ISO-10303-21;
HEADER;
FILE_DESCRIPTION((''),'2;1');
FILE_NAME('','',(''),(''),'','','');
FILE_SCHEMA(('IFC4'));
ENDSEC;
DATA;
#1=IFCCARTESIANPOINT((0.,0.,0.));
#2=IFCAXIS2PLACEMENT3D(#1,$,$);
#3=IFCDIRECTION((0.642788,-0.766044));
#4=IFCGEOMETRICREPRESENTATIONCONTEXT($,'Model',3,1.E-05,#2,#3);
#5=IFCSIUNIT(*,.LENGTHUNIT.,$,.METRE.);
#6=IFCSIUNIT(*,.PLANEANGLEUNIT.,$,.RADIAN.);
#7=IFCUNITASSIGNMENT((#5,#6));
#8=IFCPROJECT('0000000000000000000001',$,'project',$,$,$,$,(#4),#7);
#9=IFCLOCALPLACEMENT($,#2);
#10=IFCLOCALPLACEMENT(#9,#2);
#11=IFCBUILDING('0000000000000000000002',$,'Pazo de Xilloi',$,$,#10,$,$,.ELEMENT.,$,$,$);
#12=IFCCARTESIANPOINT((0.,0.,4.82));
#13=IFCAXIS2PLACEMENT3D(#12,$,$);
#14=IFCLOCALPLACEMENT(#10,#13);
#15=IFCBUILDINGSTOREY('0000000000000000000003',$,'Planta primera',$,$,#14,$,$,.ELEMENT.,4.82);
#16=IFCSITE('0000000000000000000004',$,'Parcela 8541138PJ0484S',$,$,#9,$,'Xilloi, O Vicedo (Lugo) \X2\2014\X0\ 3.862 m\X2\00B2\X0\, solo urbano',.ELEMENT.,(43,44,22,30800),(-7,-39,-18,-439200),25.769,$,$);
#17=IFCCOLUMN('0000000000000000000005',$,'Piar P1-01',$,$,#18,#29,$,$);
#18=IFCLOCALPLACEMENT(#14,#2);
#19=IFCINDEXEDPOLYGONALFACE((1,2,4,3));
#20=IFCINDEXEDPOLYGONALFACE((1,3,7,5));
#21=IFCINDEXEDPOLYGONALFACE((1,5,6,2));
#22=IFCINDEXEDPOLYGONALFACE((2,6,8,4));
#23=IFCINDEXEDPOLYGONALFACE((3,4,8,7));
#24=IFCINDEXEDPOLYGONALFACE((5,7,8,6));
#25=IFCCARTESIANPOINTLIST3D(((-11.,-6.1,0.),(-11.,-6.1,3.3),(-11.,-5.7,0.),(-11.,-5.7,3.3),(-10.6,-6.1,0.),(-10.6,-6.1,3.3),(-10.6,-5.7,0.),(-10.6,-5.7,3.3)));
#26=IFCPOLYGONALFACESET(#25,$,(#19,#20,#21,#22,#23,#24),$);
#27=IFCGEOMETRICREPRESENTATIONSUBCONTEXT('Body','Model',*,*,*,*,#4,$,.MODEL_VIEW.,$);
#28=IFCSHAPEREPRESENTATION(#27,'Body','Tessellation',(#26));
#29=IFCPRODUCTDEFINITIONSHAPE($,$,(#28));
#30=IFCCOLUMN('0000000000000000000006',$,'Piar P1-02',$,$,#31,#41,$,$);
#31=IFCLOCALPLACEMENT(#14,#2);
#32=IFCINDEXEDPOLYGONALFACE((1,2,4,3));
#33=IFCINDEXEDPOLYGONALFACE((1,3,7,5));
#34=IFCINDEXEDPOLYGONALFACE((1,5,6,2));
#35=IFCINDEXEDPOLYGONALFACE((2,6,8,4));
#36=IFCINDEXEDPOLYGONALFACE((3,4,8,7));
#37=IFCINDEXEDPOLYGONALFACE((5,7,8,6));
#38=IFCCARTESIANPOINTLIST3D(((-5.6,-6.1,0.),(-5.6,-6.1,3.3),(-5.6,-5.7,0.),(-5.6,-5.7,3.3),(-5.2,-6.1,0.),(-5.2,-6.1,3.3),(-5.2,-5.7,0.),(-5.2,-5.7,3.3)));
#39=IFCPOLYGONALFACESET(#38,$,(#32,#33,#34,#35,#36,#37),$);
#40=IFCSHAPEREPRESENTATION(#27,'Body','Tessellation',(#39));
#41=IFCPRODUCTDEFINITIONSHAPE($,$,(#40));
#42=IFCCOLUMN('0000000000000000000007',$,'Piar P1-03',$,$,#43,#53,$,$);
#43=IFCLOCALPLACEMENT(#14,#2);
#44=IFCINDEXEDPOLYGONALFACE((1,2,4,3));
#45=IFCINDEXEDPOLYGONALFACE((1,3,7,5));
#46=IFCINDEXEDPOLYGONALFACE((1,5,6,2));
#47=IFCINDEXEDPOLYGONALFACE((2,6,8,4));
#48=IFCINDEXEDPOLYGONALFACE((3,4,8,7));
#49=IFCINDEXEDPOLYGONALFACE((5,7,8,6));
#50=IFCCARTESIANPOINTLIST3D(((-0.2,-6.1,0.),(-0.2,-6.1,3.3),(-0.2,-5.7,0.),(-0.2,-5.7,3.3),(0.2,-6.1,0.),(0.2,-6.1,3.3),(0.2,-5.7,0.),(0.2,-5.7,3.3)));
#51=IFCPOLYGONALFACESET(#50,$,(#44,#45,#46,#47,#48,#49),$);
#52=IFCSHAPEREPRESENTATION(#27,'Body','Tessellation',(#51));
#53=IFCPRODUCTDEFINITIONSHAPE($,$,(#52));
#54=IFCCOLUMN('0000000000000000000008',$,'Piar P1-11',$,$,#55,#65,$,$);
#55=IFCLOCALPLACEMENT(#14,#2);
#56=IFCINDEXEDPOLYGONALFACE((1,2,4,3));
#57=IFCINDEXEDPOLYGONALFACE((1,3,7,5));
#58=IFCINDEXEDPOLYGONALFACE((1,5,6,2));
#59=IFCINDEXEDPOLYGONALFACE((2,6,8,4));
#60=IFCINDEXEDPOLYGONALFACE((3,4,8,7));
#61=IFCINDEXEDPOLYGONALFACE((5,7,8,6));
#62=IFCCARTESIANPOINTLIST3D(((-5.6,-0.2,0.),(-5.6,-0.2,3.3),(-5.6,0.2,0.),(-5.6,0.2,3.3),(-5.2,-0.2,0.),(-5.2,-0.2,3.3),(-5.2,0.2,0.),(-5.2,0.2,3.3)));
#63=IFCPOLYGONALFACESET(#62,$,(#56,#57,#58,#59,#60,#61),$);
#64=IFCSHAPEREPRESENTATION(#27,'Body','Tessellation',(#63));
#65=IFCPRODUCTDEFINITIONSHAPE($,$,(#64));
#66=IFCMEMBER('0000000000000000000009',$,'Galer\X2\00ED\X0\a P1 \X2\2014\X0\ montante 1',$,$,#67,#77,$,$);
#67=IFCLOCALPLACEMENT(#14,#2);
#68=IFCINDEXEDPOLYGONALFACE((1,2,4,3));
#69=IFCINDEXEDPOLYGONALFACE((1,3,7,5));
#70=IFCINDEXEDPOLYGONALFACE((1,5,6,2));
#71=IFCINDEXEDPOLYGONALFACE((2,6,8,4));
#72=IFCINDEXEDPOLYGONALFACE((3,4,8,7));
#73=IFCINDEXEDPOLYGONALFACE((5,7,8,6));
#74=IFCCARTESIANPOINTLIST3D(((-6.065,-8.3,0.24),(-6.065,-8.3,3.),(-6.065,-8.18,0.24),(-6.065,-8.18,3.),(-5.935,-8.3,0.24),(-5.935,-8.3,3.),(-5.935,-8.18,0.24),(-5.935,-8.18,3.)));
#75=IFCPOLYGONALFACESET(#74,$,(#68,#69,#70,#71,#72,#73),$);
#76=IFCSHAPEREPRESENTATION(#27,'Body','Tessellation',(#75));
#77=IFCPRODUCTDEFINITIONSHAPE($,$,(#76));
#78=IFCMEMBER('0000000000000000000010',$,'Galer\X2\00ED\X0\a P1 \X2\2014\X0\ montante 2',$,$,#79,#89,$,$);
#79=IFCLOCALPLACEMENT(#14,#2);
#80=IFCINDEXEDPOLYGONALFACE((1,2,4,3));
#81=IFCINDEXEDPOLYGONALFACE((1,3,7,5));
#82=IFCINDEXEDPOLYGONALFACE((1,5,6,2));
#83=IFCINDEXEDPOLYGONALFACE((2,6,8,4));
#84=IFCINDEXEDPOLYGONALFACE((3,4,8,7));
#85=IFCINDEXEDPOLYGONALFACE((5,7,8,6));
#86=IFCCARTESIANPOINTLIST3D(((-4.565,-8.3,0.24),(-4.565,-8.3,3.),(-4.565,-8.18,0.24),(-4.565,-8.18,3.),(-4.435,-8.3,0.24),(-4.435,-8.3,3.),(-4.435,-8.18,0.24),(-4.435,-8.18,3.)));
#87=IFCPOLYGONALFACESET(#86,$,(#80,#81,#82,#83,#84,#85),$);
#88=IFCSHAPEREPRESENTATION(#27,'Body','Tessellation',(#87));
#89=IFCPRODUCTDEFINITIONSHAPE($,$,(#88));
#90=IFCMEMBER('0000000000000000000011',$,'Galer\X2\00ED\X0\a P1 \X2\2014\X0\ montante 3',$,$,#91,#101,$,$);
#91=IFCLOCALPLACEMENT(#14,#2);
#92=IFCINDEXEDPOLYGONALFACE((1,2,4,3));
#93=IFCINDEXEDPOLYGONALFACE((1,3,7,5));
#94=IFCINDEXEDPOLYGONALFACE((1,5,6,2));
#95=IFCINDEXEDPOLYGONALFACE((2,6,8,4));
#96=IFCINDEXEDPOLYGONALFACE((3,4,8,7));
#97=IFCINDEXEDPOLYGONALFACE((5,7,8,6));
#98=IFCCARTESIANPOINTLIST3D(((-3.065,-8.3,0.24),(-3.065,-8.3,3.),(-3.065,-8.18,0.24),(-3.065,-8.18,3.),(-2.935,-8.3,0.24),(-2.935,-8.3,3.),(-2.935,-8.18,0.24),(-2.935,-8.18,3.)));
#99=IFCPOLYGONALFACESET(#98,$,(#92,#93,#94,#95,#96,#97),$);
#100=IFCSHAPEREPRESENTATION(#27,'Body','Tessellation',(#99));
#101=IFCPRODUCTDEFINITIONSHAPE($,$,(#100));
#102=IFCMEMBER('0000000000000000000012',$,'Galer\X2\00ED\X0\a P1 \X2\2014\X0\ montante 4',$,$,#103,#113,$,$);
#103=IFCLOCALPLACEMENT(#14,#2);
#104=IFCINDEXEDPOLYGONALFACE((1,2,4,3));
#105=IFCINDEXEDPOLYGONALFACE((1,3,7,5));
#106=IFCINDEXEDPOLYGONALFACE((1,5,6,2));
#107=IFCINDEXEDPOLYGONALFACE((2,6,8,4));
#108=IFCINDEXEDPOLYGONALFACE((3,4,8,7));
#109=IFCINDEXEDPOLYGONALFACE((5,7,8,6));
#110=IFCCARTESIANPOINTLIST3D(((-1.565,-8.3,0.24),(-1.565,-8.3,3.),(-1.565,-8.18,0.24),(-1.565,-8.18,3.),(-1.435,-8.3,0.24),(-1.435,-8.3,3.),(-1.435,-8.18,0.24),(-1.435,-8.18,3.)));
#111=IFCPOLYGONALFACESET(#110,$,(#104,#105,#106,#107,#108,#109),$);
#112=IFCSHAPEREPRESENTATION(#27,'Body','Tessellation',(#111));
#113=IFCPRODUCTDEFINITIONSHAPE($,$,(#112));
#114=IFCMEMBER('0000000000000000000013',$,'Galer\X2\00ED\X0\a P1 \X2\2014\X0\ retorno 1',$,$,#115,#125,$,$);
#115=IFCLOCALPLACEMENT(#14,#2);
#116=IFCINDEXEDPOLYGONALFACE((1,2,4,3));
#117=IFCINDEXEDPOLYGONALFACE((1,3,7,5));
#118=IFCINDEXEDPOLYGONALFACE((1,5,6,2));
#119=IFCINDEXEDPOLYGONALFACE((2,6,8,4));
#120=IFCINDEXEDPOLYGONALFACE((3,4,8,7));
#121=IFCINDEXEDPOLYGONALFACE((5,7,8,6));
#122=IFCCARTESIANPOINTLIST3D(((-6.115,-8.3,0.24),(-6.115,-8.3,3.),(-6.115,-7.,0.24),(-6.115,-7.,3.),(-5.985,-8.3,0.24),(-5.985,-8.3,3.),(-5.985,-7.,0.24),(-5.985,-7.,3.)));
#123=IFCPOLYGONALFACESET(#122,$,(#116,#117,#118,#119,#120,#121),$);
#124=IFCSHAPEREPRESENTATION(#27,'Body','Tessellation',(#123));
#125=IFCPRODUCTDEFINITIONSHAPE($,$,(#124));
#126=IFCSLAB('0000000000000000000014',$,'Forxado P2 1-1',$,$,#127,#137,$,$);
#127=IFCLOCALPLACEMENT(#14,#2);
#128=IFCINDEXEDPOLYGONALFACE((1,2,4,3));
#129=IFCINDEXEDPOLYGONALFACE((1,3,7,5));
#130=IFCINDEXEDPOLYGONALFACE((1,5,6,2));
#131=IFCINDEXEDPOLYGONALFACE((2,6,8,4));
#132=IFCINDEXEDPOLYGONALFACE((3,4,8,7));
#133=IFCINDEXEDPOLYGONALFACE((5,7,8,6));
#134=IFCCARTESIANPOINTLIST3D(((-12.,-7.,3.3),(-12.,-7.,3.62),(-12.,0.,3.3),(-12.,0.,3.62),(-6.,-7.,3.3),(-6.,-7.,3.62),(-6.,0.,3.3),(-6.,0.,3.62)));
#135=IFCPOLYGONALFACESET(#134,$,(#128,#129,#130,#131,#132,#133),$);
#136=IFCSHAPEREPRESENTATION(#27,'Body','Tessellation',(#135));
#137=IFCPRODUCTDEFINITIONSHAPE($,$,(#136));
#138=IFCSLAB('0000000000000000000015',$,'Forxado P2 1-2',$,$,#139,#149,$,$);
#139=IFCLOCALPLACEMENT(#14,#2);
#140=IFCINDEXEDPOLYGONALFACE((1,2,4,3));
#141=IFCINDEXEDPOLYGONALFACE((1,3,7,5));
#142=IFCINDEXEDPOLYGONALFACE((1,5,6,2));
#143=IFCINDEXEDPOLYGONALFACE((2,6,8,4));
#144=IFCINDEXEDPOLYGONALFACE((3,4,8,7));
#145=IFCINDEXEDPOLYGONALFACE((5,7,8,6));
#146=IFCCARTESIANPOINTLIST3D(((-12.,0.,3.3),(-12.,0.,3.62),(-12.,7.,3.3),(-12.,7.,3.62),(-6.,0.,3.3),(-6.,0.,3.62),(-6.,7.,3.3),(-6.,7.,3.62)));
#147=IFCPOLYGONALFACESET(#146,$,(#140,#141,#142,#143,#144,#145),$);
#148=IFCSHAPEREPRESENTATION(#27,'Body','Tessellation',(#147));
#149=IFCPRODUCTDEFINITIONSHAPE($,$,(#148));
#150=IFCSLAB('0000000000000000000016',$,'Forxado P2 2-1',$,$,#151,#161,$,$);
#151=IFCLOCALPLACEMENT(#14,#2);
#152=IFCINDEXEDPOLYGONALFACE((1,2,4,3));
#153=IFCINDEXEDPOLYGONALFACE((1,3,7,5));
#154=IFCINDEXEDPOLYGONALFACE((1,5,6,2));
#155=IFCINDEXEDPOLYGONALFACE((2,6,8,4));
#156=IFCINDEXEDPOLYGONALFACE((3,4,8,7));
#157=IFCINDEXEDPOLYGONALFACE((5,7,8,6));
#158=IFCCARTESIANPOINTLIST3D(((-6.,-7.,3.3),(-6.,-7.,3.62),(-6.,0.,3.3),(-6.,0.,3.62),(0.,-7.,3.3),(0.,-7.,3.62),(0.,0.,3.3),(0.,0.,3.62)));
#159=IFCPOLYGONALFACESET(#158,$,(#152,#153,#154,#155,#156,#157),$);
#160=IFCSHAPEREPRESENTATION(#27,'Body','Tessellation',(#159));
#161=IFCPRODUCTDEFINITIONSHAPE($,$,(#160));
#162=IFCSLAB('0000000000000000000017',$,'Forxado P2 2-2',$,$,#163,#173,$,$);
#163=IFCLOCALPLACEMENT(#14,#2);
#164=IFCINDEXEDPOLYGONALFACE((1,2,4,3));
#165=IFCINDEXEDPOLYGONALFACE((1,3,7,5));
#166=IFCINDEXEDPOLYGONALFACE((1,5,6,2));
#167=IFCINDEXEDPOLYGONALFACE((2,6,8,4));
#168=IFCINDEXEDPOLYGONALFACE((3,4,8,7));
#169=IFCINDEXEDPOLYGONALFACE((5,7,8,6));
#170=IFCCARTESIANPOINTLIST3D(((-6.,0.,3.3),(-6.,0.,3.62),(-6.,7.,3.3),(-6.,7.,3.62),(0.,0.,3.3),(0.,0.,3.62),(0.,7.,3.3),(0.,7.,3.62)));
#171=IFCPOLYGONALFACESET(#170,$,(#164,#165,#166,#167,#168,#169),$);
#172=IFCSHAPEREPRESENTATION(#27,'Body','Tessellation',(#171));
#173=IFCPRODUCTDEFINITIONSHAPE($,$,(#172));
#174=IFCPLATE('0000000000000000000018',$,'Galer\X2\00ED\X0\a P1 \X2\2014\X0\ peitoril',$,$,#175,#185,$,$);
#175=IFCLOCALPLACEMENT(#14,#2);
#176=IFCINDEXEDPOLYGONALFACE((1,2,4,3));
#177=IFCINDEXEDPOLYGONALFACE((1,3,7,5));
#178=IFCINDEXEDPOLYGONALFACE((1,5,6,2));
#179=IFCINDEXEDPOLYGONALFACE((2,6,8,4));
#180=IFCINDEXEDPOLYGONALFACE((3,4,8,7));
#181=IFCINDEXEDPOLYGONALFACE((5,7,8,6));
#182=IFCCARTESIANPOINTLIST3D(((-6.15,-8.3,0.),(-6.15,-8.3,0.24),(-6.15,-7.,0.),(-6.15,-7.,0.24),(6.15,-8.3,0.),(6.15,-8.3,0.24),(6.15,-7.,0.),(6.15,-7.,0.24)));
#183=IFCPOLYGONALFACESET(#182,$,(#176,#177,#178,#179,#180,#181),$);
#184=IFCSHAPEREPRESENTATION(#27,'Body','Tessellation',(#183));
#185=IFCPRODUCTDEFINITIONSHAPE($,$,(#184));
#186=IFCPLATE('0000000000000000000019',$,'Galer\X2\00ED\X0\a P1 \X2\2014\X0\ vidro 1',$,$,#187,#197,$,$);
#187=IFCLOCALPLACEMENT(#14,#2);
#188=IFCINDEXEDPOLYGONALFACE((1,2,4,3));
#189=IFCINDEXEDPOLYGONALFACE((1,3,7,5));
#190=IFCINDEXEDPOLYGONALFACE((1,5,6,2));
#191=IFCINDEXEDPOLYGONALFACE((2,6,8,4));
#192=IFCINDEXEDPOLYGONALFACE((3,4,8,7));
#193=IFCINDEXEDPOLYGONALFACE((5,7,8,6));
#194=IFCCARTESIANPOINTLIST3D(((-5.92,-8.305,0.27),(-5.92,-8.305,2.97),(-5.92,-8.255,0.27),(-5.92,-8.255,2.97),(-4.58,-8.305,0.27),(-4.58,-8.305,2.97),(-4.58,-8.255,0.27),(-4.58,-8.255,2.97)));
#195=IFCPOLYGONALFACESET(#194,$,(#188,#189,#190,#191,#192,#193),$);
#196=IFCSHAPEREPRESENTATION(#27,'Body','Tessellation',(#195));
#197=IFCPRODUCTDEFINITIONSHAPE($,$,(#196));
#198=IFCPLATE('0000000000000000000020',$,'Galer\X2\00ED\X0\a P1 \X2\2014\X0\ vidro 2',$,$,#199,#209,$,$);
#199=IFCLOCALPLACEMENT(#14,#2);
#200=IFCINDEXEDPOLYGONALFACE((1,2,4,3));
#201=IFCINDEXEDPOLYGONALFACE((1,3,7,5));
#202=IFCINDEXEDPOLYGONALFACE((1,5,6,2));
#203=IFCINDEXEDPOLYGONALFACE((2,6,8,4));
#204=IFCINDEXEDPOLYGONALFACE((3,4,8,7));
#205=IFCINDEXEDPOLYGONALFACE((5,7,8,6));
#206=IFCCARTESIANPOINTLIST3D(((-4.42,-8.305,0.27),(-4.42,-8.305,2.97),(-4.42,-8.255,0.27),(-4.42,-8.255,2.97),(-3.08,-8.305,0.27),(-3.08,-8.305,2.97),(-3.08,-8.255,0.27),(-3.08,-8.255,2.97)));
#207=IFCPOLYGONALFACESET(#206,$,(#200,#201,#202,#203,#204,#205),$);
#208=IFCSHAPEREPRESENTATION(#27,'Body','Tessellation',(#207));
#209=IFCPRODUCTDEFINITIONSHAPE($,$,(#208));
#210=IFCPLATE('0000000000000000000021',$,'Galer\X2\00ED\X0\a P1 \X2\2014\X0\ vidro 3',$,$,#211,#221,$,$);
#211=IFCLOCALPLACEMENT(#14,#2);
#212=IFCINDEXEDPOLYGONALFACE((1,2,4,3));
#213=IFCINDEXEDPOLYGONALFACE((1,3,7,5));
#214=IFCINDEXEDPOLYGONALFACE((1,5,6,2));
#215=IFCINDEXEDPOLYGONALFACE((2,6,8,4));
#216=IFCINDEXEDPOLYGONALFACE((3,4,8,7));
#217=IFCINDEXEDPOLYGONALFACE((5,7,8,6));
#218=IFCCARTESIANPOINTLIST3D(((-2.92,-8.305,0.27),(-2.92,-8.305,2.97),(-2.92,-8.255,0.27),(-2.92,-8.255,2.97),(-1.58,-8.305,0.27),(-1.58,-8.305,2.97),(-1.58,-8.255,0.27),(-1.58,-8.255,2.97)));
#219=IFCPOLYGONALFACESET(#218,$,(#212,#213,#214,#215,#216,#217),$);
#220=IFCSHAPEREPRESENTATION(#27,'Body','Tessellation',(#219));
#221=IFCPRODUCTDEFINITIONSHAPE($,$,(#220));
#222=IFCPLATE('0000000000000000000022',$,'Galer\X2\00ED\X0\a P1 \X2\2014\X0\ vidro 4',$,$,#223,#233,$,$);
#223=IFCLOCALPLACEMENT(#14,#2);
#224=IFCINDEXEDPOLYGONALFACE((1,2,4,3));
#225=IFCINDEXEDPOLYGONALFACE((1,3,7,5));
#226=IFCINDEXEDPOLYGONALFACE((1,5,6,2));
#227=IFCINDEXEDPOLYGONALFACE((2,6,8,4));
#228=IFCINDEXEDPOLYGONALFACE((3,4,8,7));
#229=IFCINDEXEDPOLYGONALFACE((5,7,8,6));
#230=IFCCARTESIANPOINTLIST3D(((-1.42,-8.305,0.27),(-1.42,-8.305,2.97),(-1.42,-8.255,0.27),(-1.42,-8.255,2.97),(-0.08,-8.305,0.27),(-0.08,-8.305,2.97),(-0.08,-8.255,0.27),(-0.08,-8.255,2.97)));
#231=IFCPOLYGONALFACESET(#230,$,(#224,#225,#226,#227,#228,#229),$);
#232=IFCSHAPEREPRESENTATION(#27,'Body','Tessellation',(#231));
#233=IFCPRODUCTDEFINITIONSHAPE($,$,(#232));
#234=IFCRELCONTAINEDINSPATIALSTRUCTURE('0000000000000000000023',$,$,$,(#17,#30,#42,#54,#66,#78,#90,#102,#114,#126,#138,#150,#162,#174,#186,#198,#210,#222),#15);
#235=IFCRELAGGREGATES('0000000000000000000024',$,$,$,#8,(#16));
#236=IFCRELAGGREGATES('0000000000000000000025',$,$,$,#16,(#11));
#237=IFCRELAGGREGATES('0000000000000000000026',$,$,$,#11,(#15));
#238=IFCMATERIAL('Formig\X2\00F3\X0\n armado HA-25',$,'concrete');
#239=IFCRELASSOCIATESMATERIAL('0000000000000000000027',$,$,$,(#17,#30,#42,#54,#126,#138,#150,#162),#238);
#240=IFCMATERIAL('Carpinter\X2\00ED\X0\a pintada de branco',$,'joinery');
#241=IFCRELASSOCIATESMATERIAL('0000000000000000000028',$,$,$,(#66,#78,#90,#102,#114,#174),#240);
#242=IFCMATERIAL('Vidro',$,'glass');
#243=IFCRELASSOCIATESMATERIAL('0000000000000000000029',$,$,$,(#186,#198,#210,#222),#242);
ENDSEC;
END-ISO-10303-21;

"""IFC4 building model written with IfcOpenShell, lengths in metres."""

from ifc_helpers import new_model, si_unit, direction, frame, origin, origin_2d, place, context, subcontext, project, spatial, rectangle, extrude, material, element, save


model = new_model("IFC4")

# Units and contexts
model_context = context("Model", 3, precision=1e-05, world=origin(), true_north=direction((0.642788, -0.766044)))
body_context = subcontext(model_context, "Body", "Model", "MODEL_VIEW")
ifc_project = project(units=[si_unit("LENGTHUNIT", "METRE"), si_unit("PLANEANGLEUNIT", "RADIAN")], contexts=[model_context])

# Site, building, storey
site_placement = place(None, origin())
site = spatial("IfcSite", under=ifc_project, at=site_placement, Name="Parcela 8541138PJ0484S", LongName="Xilloi, O Vicedo (Lugo) — 3.862 m², solo urbano", CompositionType="ELEMENT", RefLatitude=(43, 44, 22, 30800), RefLongitude=(-7, -39, -18, -439200), RefElevation=25.769)
building_placement = place(site_placement, origin())
building = spatial("IfcBuilding", under=site, at=building_placement, Name="Pazo de Xilloi", CompositionType="ELEMENT")
storey_placement = place(building_placement, frame((0.0, 0.0, 4.82)))
storey = spatial("IfcBuildingStorey", under=building, at=storey_placement, Name="Planta primera", CompositionType="ELEMENT", Elevation=4.82)

# Columns
ifc_material_1 = material(Name="Formigón armado HA-25", Category="concrete")
for number, where, name in (
    (1, (-10.8, -5.9, 1.65), "Piar P1-01"),
    (2, (-5.4, -5.9, 1.65), "Piar P1-02"),
    (3, (0.0, -5.9, 1.65), "Piar P1-03"),
    (4, (-5.4, 0.0, 1.65), "Piar P1-11"),
):
    element("IfcColumn", number, at=place(storey_placement, frame(where)), inside=storey, material=ifc_material_1, Name=name, context=body_context, shape_type="SweptSolid", body=[
        extrude(rectangle(XDim=0.4, YDim=0.4, at=origin_2d()), frame((0.0, 0.0, -1.65)), (0.0, 0.0, 1.0), 3.3),
    ])

# Members
ifc_material_2 = material(Name="Carpintería pintada de branco", Category="joinery")
for number, where, name in (
    (5, (-6.0, -8.24, 1.62), "Galería P1 — montante 1"),
    (6, (-4.5, -8.24, 1.62), "Galería P1 — montante 2"),
    (7, (-3.0, -8.24, 1.62), "Galería P1 — montante 3"),
    (8, (-1.5, -8.24, 1.62), "Galería P1 — montante 4"),
):
    element("IfcMember", number, at=place(storey_placement, frame(where)), inside=storey, material=ifc_material_2, Name=name, context=body_context, shape_type="SweptSolid", body=[
        extrude(rectangle(XDim=0.13, YDim=0.12, at=origin_2d()), frame((0.0, 0.0, -1.38)), (0.0, 0.0, 1.0), 2.76),
    ])
member_placement = place(storey_placement, frame((-6.05, -7.65, 1.62)))
element("IfcMember", 9, at=member_placement, inside=storey, material=ifc_material_2, Name="Galería P1 — retorno 1", context=body_context, shape_type="SweptSolid", body=[
    extrude(rectangle(XDim=0.13, YDim=1.3, at=origin_2d()), frame((0.0, 0.0, -1.38)), (0.0, 0.0, 1.0), 2.76),
])

# Slabs
for number, where, name in (
    (10, (-9.0, -3.5, 3.46), "Forxado P2 1-1"),
    (11, (-9.0, 3.5, 3.46), "Forxado P2 1-2"),
    (12, (-3.0, -3.5, 3.46), "Forxado P2 2-1"),
    (13, (-3.0, 3.5, 3.46), "Forxado P2 2-2"),
):
    element("IfcSlab", number, at=place(storey_placement, frame(where)), inside=storey, material=ifc_material_1, Name=name, context=body_context, shape_type="SweptSolid", body=[
        extrude(rectangle(XDim=6.0, YDim=7.0, at=origin_2d()), frame((0.0, 0.0, -0.16)), (0.0, 0.0, 1.0), 0.32),
    ])

# Plates
plate_placement = place(storey_placement, frame((0.0, -7.65, 0.12)))
element("IfcPlate", 14, at=plate_placement, inside=storey, material=ifc_material_2, Name="Galería P1 — peitoril", context=body_context, shape_type="SweptSolid", body=[
    extrude(rectangle(XDim=12.3, YDim=1.3, at=origin_2d()), frame((0.0, 0.0, -0.12)), (0.0, 0.0, 1.0), 0.24),
])
ifc_material_3 = material(Name="Vidro", Category="glass")
for number, where, name in (
    (15, (-5.25, -8.28, 1.62), "Galería P1 — vidro 1"),
    (16, (-3.75, -8.28, 1.62), "Galería P1 — vidro 2"),
    (17, (-2.25, -8.28, 1.62), "Galería P1 — vidro 3"),
    (18, (-0.75, -8.28, 1.62), "Galería P1 — vidro 4"),
):
    element("IfcPlate", number, at=place(storey_placement, frame(where)), inside=storey, material=ifc_material_3, Name=name, context=body_context, shape_type="SweptSolid", body=[
        extrude(rectangle(XDim=1.34, YDim=0.05, at=origin_2d()), frame((0.0, 0.0, -1.35)), (0.0, 0.0, 1.0), 2.7),
    ])

save(model, "model.ifc")
